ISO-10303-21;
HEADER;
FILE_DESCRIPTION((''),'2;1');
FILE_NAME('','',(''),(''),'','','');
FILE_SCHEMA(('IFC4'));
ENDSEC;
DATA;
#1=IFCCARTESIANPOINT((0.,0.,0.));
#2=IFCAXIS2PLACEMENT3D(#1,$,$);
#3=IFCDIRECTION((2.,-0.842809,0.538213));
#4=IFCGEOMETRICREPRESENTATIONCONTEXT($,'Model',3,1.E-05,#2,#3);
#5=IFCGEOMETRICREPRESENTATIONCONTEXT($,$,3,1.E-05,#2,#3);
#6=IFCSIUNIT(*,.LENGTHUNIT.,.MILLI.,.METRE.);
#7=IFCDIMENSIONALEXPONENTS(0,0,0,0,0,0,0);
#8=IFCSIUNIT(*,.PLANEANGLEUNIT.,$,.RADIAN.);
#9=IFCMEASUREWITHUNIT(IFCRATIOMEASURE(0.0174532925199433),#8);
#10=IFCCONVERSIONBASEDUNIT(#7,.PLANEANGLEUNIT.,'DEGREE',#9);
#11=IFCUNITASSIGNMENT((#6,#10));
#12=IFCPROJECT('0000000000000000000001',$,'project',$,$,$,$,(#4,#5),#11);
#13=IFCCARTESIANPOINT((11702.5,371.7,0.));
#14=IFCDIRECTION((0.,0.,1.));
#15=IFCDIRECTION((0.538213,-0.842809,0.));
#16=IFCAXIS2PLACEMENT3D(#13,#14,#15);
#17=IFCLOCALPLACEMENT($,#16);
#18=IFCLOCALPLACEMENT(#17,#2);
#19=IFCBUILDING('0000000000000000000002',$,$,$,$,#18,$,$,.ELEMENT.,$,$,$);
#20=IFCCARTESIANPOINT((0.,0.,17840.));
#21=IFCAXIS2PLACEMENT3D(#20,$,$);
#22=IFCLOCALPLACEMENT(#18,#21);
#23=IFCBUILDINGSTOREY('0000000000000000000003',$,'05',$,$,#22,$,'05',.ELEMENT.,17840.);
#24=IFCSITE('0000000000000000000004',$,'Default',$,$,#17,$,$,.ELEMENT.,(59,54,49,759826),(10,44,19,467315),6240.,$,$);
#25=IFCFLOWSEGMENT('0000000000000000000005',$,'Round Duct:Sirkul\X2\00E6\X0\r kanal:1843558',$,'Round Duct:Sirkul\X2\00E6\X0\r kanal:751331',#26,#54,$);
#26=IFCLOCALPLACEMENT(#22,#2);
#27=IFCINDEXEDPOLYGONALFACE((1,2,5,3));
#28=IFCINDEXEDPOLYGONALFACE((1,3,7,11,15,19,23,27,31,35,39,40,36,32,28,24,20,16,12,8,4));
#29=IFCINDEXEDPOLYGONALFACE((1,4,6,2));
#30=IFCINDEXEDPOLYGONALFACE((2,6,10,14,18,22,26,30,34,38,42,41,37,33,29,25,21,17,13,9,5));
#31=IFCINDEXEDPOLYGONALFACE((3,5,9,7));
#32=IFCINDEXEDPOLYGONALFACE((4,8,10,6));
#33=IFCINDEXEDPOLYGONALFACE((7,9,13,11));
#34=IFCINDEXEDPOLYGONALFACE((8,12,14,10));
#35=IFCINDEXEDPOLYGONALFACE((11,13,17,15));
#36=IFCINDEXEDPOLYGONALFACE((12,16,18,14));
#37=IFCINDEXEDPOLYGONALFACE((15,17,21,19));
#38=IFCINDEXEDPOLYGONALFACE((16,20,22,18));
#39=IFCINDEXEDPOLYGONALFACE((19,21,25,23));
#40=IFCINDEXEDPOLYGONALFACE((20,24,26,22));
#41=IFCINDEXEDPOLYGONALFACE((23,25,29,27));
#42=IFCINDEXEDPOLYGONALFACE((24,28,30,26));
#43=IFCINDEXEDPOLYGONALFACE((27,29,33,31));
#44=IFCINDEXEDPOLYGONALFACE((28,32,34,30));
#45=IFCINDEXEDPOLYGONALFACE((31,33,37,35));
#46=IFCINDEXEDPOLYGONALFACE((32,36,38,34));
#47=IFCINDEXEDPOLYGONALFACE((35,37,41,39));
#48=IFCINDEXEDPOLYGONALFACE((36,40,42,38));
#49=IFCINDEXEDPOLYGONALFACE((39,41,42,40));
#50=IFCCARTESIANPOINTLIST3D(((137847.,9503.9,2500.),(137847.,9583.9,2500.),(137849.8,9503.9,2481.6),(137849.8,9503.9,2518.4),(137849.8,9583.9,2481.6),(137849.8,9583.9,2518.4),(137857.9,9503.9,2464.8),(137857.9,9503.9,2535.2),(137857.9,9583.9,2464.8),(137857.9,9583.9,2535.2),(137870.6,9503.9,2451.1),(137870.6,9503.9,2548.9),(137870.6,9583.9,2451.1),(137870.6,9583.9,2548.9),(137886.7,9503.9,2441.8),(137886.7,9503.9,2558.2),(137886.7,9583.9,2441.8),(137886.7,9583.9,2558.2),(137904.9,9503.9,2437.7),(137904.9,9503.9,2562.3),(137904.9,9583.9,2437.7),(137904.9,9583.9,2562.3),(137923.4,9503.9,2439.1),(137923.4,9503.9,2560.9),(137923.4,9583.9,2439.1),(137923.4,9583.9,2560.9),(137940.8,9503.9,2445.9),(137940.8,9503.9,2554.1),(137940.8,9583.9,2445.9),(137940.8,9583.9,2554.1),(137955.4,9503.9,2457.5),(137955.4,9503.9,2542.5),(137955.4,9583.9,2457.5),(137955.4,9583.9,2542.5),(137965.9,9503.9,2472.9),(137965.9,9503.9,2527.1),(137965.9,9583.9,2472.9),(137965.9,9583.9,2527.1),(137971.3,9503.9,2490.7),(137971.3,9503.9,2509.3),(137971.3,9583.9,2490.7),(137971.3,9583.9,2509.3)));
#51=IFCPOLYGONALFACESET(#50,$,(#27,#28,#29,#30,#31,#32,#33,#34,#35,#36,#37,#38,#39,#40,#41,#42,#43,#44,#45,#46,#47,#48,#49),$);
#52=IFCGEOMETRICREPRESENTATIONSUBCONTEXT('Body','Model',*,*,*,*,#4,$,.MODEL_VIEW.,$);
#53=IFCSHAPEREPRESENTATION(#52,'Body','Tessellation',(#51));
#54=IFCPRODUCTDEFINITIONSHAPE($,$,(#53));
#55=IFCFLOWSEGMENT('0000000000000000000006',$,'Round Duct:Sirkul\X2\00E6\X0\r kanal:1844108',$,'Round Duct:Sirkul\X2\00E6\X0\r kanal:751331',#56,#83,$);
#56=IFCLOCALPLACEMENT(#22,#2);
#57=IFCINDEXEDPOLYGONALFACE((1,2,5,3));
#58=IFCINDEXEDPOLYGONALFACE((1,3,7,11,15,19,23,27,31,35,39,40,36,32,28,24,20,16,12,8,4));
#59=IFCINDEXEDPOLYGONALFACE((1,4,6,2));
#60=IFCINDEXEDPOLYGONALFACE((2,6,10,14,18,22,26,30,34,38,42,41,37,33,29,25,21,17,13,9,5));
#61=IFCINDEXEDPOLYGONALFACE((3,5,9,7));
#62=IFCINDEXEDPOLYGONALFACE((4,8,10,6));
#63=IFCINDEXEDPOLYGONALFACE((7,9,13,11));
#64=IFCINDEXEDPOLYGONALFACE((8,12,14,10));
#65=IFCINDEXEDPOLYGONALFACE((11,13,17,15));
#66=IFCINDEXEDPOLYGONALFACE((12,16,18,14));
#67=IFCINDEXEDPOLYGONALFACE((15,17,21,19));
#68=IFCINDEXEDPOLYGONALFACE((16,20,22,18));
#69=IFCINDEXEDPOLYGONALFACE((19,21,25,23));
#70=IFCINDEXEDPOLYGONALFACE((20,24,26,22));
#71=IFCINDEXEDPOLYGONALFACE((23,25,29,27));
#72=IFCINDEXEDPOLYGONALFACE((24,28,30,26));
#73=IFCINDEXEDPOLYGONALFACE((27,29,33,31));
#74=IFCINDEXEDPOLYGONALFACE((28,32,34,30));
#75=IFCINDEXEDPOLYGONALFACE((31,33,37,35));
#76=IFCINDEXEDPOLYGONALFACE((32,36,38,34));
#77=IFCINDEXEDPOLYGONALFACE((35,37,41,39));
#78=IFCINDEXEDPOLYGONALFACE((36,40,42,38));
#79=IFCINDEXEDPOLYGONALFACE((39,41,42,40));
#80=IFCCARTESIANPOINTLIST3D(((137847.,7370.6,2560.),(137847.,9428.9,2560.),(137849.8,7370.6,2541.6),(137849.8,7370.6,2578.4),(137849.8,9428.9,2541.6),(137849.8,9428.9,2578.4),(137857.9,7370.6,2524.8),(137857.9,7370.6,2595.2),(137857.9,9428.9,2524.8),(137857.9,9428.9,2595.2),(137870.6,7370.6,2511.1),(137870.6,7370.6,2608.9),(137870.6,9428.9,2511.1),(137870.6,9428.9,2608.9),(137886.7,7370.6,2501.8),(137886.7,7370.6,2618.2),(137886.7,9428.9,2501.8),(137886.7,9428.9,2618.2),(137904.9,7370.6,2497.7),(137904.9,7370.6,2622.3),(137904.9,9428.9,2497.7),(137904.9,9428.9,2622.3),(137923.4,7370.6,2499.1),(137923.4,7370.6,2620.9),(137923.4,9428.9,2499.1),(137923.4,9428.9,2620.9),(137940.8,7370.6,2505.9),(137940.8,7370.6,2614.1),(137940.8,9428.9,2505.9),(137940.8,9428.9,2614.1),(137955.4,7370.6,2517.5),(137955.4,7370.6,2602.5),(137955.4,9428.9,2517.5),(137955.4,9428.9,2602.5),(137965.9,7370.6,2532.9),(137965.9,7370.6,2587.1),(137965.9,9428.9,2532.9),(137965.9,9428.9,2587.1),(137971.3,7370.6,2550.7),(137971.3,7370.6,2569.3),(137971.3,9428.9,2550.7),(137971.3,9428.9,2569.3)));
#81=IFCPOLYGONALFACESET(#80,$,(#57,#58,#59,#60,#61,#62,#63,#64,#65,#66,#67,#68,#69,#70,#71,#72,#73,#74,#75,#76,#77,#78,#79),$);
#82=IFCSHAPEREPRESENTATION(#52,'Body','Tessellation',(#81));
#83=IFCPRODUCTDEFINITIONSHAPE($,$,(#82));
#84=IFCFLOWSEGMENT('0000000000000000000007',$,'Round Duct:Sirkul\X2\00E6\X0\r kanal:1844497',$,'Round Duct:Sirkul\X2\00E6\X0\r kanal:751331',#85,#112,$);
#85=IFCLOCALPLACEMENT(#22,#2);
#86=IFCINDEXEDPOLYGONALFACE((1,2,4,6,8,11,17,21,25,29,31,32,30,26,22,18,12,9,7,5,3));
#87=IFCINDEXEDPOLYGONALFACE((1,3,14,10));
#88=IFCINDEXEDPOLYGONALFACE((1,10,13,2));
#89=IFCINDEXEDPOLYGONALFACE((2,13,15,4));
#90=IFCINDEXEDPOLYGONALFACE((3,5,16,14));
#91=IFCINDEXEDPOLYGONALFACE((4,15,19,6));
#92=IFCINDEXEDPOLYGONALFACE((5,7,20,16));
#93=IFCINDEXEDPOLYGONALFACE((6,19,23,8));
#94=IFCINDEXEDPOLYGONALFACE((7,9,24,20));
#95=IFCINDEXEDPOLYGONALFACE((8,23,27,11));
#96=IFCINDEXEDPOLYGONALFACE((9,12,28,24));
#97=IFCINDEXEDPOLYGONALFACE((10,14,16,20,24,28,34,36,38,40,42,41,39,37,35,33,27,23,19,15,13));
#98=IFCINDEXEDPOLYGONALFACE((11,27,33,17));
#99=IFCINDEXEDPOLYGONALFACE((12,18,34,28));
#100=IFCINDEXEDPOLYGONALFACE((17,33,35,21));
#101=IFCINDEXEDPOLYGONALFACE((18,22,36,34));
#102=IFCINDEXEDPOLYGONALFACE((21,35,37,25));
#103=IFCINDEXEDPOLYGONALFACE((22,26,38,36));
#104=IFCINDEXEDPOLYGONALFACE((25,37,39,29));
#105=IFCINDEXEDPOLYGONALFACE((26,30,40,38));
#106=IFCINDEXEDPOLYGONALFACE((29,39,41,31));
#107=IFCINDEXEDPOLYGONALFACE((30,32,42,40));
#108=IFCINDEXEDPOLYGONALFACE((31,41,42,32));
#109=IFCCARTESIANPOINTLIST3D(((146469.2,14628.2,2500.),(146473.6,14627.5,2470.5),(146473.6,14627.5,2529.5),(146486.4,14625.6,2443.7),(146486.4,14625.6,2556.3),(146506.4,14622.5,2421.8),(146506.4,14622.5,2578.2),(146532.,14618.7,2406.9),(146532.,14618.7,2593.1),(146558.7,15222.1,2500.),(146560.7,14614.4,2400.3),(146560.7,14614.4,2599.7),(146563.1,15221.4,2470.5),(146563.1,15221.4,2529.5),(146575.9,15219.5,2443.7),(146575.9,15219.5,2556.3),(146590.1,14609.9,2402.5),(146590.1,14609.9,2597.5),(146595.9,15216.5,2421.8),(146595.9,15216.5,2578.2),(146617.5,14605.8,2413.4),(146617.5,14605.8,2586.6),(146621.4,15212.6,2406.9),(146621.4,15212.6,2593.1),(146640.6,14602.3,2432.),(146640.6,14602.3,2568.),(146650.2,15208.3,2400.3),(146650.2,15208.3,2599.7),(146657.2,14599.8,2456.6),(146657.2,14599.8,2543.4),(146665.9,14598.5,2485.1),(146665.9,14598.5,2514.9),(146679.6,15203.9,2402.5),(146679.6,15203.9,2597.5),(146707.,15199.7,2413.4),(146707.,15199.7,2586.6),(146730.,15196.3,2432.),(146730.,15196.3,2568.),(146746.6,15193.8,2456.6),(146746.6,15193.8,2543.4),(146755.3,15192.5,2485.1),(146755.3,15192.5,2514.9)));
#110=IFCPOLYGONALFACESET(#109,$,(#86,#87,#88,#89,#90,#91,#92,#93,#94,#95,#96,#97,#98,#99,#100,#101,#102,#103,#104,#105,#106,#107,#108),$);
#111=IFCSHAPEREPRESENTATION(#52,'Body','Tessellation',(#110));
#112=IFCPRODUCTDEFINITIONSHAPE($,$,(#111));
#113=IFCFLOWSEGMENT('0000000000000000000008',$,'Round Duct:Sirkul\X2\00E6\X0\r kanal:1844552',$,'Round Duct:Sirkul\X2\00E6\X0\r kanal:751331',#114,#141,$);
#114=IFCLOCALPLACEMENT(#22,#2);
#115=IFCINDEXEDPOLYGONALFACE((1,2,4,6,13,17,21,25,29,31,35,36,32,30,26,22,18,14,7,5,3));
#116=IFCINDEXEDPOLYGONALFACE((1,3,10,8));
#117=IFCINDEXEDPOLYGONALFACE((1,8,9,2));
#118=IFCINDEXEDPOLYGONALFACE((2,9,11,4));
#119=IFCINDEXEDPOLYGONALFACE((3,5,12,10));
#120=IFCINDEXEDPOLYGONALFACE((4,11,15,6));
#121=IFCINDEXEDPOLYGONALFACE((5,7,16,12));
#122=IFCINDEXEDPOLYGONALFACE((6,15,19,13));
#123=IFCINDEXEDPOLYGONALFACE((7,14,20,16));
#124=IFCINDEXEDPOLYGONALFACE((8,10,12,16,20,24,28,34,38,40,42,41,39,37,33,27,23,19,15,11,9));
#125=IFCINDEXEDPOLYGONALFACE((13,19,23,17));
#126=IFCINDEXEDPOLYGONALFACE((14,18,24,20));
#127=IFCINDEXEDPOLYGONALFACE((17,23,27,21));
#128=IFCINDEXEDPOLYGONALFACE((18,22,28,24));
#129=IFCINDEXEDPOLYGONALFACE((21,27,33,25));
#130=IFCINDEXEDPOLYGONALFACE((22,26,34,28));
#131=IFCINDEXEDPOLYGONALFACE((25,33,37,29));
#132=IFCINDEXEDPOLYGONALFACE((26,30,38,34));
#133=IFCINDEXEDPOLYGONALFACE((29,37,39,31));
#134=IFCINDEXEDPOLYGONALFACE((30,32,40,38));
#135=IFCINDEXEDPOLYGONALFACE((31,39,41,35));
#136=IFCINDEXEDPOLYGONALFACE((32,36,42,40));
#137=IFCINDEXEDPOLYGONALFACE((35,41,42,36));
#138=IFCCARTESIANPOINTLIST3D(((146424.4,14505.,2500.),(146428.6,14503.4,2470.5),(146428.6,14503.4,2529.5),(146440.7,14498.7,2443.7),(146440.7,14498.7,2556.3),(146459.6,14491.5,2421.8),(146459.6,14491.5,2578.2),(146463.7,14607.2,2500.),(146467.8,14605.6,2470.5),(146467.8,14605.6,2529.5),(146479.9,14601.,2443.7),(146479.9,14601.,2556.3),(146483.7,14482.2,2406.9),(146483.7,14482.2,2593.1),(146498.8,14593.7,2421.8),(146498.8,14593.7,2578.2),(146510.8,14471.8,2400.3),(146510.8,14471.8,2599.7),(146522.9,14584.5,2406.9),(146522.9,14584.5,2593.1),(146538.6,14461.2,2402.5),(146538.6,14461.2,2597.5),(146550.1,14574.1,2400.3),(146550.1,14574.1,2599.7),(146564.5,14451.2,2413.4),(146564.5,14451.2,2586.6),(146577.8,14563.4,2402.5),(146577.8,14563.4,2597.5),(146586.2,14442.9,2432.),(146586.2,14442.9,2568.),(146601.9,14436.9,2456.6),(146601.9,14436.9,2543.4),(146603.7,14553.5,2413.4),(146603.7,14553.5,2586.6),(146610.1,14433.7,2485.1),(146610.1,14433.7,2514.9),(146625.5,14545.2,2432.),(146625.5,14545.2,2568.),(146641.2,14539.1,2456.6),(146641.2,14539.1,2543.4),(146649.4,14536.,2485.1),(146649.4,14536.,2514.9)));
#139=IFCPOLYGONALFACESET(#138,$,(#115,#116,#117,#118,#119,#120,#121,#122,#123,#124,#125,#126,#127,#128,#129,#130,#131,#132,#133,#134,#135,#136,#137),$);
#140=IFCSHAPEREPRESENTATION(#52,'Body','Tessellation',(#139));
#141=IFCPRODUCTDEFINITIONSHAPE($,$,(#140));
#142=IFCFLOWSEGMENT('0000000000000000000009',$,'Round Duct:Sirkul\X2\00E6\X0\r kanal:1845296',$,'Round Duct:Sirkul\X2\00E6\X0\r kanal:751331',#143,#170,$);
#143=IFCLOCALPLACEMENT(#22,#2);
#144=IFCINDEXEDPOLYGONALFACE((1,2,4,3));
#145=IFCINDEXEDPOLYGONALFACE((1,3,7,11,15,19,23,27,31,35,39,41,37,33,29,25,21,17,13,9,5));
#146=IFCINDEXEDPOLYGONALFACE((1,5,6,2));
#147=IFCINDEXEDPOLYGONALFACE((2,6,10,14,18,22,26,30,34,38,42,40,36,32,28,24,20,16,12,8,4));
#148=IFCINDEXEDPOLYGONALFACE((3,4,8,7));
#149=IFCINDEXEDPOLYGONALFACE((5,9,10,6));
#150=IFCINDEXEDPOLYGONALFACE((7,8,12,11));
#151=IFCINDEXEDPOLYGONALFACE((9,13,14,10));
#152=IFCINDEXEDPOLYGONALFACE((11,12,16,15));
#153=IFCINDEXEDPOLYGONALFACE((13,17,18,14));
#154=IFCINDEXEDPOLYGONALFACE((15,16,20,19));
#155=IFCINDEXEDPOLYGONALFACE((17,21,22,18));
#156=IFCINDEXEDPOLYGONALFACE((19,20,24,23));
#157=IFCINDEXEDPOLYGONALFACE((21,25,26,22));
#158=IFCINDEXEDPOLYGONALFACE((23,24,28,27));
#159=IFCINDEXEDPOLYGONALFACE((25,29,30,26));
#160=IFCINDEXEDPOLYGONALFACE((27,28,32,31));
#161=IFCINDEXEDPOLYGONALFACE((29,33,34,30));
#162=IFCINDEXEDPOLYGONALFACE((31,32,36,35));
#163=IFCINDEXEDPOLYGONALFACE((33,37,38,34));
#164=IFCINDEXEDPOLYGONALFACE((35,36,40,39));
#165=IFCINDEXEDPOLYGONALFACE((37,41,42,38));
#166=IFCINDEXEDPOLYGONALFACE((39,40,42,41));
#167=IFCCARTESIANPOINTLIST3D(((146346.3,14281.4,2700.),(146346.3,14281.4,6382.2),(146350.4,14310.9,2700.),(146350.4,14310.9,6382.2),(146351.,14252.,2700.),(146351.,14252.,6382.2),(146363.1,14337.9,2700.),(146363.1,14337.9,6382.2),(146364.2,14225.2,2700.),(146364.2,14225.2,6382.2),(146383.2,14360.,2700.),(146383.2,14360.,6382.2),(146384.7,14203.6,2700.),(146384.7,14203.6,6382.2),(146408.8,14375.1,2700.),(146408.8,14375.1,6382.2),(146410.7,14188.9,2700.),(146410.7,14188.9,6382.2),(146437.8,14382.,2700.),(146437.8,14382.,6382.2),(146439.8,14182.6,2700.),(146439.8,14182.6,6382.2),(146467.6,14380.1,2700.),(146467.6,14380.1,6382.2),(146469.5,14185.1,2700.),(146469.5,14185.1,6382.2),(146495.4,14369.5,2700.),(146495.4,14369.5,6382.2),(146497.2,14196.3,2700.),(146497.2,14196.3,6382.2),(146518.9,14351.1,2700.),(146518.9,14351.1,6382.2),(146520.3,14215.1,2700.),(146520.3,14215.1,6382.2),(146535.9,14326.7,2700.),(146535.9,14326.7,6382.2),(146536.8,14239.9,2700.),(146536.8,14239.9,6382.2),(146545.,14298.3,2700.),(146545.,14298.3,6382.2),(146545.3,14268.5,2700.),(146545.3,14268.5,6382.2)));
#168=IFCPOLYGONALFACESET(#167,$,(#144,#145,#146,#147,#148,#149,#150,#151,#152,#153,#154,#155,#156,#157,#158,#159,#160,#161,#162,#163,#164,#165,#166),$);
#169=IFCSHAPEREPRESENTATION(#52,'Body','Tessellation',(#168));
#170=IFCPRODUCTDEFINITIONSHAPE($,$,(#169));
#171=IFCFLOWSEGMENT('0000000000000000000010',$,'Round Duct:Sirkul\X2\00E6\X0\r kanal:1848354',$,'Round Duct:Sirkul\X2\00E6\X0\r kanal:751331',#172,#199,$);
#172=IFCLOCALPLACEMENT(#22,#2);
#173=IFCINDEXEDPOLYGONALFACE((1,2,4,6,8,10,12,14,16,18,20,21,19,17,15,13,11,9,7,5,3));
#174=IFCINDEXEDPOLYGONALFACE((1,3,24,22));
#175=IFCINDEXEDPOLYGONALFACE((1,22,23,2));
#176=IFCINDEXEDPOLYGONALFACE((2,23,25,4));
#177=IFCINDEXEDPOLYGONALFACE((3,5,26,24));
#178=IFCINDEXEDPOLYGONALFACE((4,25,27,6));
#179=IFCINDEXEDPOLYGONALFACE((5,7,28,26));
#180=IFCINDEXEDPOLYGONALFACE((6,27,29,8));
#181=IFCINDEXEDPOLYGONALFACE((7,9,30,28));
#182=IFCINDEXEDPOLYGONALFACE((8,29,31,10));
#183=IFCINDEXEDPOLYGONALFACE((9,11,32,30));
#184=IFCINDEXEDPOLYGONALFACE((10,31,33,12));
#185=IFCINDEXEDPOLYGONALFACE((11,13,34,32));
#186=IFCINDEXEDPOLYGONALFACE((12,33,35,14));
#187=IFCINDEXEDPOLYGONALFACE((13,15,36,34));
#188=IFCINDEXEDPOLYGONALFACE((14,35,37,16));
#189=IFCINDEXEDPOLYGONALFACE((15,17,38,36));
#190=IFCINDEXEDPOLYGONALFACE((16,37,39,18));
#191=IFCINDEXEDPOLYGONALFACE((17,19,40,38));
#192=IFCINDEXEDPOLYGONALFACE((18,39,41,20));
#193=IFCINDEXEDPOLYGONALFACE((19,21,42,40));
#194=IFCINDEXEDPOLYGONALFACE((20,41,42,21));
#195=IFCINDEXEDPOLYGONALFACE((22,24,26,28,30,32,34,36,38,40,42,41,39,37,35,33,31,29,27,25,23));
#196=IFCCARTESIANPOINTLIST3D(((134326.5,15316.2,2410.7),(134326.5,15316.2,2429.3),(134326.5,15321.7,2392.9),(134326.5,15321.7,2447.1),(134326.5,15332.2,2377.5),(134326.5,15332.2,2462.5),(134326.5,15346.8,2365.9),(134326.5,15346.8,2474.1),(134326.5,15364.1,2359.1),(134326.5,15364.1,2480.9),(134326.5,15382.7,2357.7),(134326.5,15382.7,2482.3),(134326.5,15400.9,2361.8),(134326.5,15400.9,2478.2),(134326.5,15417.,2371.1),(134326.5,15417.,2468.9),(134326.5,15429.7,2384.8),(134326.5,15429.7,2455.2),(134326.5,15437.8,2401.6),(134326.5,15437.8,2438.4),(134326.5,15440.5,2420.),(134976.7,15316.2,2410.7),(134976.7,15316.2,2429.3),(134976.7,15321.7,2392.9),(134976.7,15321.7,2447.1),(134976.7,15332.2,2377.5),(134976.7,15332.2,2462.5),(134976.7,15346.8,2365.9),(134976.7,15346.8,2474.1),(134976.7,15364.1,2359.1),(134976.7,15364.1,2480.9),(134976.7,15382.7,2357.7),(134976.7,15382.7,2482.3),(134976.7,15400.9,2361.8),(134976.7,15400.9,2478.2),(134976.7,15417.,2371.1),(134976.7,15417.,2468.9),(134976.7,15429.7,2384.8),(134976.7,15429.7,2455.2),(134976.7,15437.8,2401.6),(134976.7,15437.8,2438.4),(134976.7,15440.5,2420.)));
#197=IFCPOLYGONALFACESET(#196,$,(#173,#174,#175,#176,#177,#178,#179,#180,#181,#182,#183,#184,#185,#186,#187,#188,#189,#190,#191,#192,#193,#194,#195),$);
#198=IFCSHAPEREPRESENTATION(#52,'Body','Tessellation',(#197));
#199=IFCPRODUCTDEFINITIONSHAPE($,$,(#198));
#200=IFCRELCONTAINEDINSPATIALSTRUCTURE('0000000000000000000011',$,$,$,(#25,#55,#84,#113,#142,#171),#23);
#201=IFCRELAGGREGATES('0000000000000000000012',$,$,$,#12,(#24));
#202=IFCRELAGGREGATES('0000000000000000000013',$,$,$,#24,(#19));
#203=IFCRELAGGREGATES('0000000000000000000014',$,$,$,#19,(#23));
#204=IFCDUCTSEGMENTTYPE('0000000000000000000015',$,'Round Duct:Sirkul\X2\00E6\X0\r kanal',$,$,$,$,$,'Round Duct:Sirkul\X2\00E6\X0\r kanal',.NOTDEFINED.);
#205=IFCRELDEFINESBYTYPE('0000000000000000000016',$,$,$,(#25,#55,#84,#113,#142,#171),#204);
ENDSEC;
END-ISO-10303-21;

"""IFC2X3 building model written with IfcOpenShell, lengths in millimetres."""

from ifc_helpers import new_model, entity, si_unit, converted_unit, direction, frame, frame_2d, origin, origin_2d_with_axis, place, context, subcontext, project, spatial, circle, extrude, type_object, element, save


model = new_model("IFC2X3")

# Units and contexts
model_context = context("Model", 3, precision=1e-05, world=origin(), true_north=direction((2.0, -0.842809, 0.538213)))
context_of_model = context(None, 3, precision=1e-05, world=origin(), true_north=direction((2.0, -0.842809, 0.538213)))
body_context = subcontext(model_context, "Body", "Model", "MODEL_VIEW")
ifc_project = project(units=[si_unit("LENGTHUNIT", "METRE", prefix="MILLI"), converted_unit("PLANEANGLEUNIT", "DEGREE", entity("IfcRatioMeasure", 0.0174532925199433), si_unit("PLANEANGLEUNIT", "RADIAN"), dimensions=[0, 0, 0, 0, 0, 0, 0])], contexts=[model_context, context_of_model])

# Site, building, storey
site_placement = place(None, frame((11702.5, 371.7, 0.0), z_axis=(0.0, 0.0, 1.0), x_axis=(0.538213, -0.842809, 0.0)))
site = spatial("IfcSite", under=ifc_project, at=site_placement, Name="Default", CompositionType="ELEMENT", RefLatitude=(59, 54, 49, 759826), RefLongitude=(10, 44, 19, 467315), RefElevation=6240.0)
building_placement = place(site_placement, origin())
building = spatial("IfcBuilding", under=site, at=building_placement, CompositionType="ELEMENT")
storey_placement = place(building_placement, frame((0.0, 0.0, 17840.0)))
storey = spatial("IfcBuildingStorey", under=building, at=storey_placement, Name="05", LongName="05", CompositionType="ELEMENT", Elevation=17840.0)

# Flow segments
duct_segment_type_1 = type_object("IfcDuctSegmentType", Name="Round Duct:Sirkulær kanal", ElementType="Round Duct:Sirkulær kanal", PredefinedType="NOTDEFINED")
flow_segment_1_placement = place(storey_placement, origin())
element("IfcFlowSegment", 1, at=flow_segment_1_placement, inside=storey, type_object=duct_segment_type_1, Name="Round Duct:Sirkulær kanal:1843558", ObjectType="Round Duct:Sirkulær kanal:751331", context=body_context, shape_type="SweptSolid", body=[
    extrude(circle(Radius=62.5, at=origin_2d_with_axis()), frame((137909.5, 9503.9, 2500.0), z_axis=(0.0, 1.0, 0.0), x_axis=(-1.0, 0.0, 0.0)), (0.0, 0.0, 1.0), 80.0),
])
flow_segment_2_placement = place(storey_placement, origin())
element("IfcFlowSegment", 2, at=flow_segment_2_placement, inside=storey, type_object=duct_segment_type_1, Name="Round Duct:Sirkulær kanal:1844108", ObjectType="Round Duct:Sirkulær kanal:751331", context=body_context, shape_type="SweptSolid", body=[
    extrude(circle(Radius=62.5, at=frame_2d((0.0, 0.0), x_axis=(1.0, 0.0))), frame((137909.5, 7370.6, 2560.0), z_axis=(0.0, 1.0, 0.0), x_axis=(-1.0, 0.0, 0.0)), (0.0, 0.0, 1.0), 2058.3),
])
flow_segment_3_placement = place(storey_placement, origin())
element("IfcFlowSegment", 3, at=flow_segment_3_placement, inside=storey, type_object=duct_segment_type_1, Name="Round Duct:Sirkulær kanal:1844497", ObjectType="Round Duct:Sirkulær kanal:751331", context=body_context, shape_type="SweptSolid", body=[
    extrude(circle(Radius=100.0, at=origin_2d_with_axis()), frame((146568.1, 14613.3, 2500.0), z_axis=(0.14896, 0.988843, 0.0), x_axis=(-0.988843, 0.14896, 0.0)), (0.0, 0.0, 1.0), 600.6),
])
flow_segment_4_placement = place(storey_placement, origin())
element("IfcFlowSegment", 4, at=flow_segment_4_placement, inside=storey, type_object=duct_segment_type_1, Name="Round Duct:Sirkulær kanal:1844552", ObjectType="Round Duct:Sirkulær kanal:751331", context=body_context, shape_type="SweptSolid", body=[
    extrude(circle(Radius=100.0, at=origin_2d_with_axis()), frame((146517.8, 14469.1, 2500.0), z_axis=(0.358187, 0.93365, 0.0), x_axis=(-0.93365, 0.358187, 0.0)), (0.0, 0.0, 1.0), 109.5),
])
flow_segment_5_placement = place(storey_placement, origin())
element("IfcFlowSegment", 5, at=flow_segment_5_placement, inside=storey, type_object=duct_segment_type_1, Name="Round Duct:Sirkulær kanal:1845296", ObjectType="Round Duct:Sirkulær kanal:751331", context=body_context, shape_type="SweptSolid", body=[
    extrude(circle(Radius=100.0, at=origin_2d_with_axis()), frame((146446.3, 14282.4, 2700.0), z_axis=(0.0, 0.0, 1.0), x_axis=(0.990268, -0.139173, 0.0)), (0.0, 0.0, 1.0), 3682.2),
])
flow_segment_6_placement = place(storey_placement, origin())
element("IfcFlowSegment", 6, at=flow_segment_6_placement, inside=storey, type_object=duct_segment_type_1, Name="Round Duct:Sirkulær kanal:1848354", ObjectType="Round Duct:Sirkulær kanal:751331", context=body_context, shape_type="SweptSolid", body=[
    extrude(circle(Radius=62.5, at=frame_2d((0.0, 0.0), x_axis=(1.0, 0.0))), frame((134326.5, 15378.0, 2420.0), z_axis=(1.0, 0.0, 0.0), x_axis=(0.0, 1.0, 0.0)), (0.0, 0.0, 1.0), 650.3),
])

save(model, "model.ifc")
